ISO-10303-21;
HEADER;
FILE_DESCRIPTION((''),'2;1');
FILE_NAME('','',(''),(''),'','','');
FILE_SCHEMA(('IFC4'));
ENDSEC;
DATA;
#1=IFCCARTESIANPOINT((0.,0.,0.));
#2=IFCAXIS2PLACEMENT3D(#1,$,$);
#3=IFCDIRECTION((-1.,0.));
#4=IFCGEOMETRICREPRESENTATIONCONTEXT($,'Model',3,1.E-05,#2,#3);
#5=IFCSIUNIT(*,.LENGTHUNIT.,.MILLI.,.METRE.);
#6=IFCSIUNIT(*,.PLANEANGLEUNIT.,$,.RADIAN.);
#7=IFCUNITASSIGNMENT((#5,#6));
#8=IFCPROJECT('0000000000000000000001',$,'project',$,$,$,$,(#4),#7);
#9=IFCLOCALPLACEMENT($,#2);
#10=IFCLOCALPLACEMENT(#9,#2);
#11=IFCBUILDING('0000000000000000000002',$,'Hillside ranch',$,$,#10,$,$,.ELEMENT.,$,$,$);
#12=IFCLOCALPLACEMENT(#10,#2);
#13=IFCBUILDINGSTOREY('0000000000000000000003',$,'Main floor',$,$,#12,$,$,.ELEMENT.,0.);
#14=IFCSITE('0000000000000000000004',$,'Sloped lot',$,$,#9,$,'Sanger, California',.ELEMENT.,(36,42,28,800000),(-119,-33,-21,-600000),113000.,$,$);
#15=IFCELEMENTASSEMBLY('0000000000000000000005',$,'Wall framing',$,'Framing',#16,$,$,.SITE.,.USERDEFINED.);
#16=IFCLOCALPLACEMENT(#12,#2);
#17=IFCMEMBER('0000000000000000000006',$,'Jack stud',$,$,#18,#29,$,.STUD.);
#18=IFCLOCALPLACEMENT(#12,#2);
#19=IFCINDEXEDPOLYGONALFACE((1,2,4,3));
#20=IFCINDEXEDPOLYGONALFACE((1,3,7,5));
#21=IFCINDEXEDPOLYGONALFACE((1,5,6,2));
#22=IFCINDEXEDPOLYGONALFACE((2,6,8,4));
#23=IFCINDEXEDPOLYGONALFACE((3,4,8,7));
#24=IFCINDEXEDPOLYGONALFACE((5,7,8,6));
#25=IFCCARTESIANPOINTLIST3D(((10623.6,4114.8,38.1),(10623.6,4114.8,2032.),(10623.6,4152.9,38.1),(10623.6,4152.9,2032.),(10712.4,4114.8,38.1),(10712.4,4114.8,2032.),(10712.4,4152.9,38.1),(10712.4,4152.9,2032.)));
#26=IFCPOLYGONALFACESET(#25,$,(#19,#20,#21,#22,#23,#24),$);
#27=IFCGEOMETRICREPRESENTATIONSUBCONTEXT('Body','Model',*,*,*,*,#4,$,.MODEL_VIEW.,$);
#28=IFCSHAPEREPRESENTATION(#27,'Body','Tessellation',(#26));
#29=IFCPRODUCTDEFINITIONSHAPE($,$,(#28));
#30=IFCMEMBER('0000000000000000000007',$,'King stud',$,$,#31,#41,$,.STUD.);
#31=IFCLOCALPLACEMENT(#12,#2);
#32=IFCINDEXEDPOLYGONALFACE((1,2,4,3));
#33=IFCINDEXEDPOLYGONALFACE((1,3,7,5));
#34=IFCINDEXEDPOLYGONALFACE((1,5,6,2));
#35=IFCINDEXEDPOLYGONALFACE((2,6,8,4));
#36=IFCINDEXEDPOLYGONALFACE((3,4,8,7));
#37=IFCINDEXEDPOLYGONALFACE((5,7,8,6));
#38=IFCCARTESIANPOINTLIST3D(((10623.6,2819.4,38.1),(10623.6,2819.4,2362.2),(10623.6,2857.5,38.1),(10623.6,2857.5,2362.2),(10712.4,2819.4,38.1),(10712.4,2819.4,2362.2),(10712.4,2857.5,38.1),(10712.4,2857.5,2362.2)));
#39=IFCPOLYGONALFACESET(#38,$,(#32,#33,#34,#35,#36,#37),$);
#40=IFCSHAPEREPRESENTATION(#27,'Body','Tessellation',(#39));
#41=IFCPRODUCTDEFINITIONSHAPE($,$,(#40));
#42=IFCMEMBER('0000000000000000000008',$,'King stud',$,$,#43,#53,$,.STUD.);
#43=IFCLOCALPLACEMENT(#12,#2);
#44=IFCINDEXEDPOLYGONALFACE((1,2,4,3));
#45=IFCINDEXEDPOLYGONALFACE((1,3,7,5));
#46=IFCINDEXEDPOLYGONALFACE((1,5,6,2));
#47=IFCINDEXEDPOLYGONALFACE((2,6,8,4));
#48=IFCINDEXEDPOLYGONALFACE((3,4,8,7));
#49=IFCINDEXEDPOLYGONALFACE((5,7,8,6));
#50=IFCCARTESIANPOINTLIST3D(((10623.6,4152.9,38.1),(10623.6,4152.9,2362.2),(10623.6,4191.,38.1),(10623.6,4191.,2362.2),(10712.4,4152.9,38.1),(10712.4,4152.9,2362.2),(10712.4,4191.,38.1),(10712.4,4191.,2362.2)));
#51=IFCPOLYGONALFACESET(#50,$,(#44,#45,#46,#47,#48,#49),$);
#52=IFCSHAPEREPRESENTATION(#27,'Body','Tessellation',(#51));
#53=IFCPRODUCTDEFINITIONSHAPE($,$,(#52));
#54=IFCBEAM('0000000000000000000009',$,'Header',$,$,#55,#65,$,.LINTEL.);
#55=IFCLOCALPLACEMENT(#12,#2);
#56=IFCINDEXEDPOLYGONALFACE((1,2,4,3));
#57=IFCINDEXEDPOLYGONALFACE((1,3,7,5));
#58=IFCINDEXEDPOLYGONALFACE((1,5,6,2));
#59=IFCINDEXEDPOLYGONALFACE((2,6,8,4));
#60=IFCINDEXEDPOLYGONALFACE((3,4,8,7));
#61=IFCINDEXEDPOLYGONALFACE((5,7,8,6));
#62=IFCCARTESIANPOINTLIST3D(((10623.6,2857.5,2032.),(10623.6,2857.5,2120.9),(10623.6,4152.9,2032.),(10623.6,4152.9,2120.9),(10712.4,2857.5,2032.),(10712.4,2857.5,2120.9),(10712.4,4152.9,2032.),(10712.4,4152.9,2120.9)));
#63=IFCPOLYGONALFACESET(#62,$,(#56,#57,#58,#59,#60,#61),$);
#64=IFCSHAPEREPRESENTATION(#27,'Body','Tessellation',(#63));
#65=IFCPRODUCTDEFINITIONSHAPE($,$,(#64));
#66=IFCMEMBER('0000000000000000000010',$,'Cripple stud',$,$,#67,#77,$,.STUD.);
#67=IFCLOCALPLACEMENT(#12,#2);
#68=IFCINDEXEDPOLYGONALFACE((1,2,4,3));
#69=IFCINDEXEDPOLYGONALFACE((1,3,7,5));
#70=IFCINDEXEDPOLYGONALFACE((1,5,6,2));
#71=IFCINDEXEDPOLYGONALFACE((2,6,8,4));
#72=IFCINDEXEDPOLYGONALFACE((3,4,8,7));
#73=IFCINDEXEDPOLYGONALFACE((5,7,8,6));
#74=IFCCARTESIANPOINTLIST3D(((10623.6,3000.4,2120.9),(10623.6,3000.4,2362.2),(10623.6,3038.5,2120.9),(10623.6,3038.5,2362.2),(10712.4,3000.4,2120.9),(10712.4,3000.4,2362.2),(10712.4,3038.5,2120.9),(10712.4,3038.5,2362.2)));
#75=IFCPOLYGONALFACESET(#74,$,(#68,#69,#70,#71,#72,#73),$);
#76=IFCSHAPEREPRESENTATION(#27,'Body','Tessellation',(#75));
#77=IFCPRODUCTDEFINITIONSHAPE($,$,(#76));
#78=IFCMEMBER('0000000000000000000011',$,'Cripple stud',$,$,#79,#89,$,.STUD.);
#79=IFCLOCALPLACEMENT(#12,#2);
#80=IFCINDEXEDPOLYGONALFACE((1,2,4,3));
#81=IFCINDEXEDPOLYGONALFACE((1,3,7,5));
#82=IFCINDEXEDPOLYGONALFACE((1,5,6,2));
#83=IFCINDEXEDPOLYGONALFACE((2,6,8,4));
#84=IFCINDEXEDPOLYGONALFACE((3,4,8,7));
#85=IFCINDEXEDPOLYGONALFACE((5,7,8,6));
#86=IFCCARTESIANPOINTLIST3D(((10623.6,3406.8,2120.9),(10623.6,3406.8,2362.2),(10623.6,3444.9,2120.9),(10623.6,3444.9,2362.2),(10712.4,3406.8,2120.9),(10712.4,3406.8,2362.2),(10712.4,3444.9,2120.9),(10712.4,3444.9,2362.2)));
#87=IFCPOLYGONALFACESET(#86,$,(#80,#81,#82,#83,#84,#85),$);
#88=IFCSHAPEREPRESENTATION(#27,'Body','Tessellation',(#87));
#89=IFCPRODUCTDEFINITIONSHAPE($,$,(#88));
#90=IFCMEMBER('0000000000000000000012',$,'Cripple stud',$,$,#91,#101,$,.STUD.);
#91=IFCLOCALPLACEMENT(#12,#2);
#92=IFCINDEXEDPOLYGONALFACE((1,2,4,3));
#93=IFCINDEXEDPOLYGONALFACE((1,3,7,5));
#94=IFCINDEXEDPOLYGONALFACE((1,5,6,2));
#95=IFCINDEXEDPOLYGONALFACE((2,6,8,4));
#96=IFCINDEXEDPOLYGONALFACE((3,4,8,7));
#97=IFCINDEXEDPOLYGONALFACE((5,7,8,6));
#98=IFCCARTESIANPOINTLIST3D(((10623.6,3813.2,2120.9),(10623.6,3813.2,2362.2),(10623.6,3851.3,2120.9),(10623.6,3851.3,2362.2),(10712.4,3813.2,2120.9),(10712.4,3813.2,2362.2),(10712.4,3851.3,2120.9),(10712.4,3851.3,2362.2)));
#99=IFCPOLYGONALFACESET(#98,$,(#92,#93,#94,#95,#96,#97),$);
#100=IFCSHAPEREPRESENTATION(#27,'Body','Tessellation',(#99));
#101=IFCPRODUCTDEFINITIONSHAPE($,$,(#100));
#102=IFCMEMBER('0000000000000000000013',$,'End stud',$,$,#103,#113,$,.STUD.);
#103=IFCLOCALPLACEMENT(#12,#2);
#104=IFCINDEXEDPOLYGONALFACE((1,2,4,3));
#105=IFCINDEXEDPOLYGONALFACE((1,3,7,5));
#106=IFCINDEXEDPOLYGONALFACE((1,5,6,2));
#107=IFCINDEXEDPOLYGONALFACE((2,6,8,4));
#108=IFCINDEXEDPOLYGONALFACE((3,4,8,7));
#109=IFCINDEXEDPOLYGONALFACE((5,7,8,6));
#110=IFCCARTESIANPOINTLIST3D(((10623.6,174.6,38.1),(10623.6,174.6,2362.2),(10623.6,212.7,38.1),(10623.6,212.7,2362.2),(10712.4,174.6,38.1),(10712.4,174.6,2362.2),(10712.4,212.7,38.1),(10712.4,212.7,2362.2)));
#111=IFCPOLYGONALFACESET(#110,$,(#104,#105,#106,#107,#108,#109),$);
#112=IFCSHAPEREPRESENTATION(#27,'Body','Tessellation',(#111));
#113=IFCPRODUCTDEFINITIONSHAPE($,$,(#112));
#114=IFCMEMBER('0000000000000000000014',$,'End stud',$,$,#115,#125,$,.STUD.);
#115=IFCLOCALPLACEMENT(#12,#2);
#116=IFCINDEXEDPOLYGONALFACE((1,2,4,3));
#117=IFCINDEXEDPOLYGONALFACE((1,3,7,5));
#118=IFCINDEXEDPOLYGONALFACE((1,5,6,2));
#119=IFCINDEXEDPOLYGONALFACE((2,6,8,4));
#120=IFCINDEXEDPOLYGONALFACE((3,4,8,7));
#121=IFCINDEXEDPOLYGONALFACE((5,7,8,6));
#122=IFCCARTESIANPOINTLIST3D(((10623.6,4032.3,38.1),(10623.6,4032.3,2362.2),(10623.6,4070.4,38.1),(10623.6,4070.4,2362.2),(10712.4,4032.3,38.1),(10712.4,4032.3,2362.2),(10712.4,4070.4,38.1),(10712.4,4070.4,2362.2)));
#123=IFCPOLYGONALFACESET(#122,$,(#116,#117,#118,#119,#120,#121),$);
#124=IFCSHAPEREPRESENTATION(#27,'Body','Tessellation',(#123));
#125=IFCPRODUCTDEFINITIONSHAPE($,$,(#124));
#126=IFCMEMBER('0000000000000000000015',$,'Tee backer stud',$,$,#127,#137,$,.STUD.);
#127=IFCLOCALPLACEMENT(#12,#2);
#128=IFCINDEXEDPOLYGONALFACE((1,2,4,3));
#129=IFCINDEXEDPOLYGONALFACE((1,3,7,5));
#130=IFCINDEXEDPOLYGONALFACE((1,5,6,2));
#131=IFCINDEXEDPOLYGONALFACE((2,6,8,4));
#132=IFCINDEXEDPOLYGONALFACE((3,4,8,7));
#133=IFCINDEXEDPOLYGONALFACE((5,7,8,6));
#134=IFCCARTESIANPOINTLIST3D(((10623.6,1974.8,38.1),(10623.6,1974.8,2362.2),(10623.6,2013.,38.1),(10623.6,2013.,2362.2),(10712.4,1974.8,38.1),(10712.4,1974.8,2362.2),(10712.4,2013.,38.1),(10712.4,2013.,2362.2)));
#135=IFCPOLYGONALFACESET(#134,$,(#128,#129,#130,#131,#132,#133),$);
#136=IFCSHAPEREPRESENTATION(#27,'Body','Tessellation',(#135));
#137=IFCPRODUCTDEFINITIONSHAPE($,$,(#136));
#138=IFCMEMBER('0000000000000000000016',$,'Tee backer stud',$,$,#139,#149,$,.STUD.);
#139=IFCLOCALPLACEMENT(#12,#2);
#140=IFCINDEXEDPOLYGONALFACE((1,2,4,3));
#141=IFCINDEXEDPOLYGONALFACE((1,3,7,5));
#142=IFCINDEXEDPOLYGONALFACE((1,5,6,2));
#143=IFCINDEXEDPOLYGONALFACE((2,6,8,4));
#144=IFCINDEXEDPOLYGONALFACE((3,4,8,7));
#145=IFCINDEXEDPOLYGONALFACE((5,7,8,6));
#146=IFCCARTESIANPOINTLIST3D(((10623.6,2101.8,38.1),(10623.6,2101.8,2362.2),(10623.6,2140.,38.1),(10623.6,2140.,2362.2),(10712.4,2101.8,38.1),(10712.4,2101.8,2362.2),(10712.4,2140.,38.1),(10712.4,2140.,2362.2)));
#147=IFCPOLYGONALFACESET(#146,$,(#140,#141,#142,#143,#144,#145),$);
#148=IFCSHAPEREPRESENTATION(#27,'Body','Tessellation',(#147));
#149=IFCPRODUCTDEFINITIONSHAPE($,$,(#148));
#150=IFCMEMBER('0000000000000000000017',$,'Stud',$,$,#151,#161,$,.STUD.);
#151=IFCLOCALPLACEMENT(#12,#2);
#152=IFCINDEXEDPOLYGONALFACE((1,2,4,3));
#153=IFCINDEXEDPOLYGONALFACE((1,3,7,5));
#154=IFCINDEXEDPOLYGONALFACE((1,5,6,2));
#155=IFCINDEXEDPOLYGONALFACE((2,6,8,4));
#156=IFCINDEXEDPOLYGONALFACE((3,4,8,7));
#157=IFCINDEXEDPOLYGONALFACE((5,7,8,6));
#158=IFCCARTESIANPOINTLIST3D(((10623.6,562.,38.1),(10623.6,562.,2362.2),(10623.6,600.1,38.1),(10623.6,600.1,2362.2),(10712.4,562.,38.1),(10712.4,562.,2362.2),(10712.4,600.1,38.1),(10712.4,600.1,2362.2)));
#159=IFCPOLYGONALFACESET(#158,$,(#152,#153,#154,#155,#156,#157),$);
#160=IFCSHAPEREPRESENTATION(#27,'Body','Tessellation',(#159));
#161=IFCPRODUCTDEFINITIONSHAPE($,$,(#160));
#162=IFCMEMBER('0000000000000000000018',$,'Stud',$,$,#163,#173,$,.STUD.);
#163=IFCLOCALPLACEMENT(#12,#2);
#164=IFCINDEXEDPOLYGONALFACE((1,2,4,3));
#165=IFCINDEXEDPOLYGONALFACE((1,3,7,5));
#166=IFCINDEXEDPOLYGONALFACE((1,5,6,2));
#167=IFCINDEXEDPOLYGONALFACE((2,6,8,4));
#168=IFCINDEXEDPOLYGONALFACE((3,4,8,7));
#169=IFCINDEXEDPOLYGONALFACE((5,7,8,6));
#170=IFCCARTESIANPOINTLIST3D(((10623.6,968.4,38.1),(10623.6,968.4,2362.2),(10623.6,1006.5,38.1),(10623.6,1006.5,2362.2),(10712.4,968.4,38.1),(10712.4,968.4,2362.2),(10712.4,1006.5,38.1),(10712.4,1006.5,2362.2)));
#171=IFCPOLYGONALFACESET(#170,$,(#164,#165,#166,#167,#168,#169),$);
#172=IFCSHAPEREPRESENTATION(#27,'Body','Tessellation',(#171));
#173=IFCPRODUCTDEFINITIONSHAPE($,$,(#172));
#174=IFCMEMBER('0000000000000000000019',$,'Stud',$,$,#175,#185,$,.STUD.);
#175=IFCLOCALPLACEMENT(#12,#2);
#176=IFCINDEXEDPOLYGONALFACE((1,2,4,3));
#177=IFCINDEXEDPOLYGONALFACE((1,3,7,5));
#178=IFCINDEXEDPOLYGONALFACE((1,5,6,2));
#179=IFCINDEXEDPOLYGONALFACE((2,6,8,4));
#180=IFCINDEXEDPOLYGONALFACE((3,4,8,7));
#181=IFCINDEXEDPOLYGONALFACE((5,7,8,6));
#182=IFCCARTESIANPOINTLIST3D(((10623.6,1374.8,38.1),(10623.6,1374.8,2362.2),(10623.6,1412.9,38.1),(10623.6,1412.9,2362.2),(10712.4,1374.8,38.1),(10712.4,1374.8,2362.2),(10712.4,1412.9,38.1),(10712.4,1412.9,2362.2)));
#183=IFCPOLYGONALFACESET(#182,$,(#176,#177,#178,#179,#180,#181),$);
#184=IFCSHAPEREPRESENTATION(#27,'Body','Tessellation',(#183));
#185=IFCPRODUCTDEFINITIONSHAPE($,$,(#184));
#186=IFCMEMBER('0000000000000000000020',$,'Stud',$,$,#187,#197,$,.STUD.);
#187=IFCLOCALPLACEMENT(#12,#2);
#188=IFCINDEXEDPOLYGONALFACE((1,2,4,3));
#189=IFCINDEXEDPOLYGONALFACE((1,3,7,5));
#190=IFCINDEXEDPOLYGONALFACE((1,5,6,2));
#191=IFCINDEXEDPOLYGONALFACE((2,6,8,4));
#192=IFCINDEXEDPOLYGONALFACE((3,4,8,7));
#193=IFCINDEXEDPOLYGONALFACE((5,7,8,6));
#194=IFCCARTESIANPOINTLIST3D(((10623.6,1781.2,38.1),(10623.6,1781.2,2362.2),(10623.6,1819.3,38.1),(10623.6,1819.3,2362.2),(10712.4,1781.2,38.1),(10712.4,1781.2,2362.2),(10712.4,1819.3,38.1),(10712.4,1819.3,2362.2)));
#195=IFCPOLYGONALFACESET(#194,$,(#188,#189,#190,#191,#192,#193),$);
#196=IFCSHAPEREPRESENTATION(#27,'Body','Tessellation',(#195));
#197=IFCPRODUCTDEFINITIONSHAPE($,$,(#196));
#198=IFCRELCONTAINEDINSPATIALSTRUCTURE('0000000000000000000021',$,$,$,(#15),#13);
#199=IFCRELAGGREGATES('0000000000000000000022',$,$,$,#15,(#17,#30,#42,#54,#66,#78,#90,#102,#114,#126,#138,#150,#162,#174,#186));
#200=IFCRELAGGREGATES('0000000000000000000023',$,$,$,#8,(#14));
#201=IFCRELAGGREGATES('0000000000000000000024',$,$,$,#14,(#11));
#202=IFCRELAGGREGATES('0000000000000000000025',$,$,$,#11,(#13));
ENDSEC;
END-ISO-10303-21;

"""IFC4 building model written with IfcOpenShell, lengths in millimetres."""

from ifc_helpers import new_model, si_unit, direction, frame, origin, origin_with_axes, place, context, subcontext, project, spatial, polyline, outline, extrude, element, aggregate, save


model = new_model("IFC4")

# Units and contexts
model_context = context("Model", 3, precision=1e-05, world=origin(), true_north=direction((-1.0, 0.0)))
body_context = subcontext(model_context, "Body", "Model", "MODEL_VIEW")
ifc_project = project(units=[si_unit("LENGTHUNIT", "METRE", prefix="MILLI"), si_unit("PLANEANGLEUNIT", "RADIAN")], contexts=[model_context])

# Site, building, storey
site_placement = place(None, origin())
site = spatial("IfcSite", under=ifc_project, at=site_placement, Name="Sloped lot", LongName="Sanger, California", CompositionType="ELEMENT", RefLatitude=(36, 42, 28, 800000), RefLongitude=(-119, -33, -21, -600000), RefElevation=113000.0)
building_placement = place(site_placement, origin())
building = spatial("IfcBuilding", under=site, at=building_placement, Name="Hillside ranch", CompositionType="ELEMENT")
storey_placement = place(building_placement, origin())
storey = spatial("IfcBuildingStorey", under=building, at=storey_placement, Name="Main floor", CompositionType="ELEMENT", Elevation=0.0)

# Element assembly, members, beam
assembly_placement = place(storey_placement, origin_with_axes())
assembly = element("IfcElementAssembly", 1, at=assembly_placement, inside=storey, Name="Wall framing", ObjectType="Framing", AssemblyPlace="SITE", PredefinedType="USERDEFINED")
member_1_placement = place(storey_placement, origin_with_axes())
member_1 = element("IfcMember", 2, at=member_1_placement, Name="Jack stud", PredefinedType="STUD", context=body_context, shape_type="SweptSolid", body=[
    extrude(outline(polyline([(0.0, 0.0), (38.1, 0.0), (38.1, 88.9), (0.0, 88.9), (0.0, 0.0)])), frame((10712.5, 4114.8, 38.1), z_axis=(0.0, 0.0, 1.0), x_axis=(0.0, 1.0, 0.0)), (0.0, 0.0, 1.0), 1993.9),
])
member_2_placement = place(storey_placement, origin_with_axes())
member_2 = element("IfcMember", 3, at=member_2_placement, Name="King stud", PredefinedType="STUD", context=body_context, shape_type="SweptSolid", body=[
    extrude(outline(polyline([(0.0, 0.0), (38.1, 0.0), (38.1, 88.9), (0.0, 88.9), (0.0, 0.0)])), frame((10712.5, 2819.4, 38.1), z_axis=(0.0, 0.0, 1.0), x_axis=(0.0, 1.0, 0.0)), (0.0, 0.0, 1.0), 2324.1),
])
member_3_placement = place(storey_placement, origin_with_axes())
member_3 = element("IfcMember", 4, at=member_3_placement, Name="King stud", PredefinedType="STUD", context=body_context, shape_type="SweptSolid", body=[
    extrude(outline(polyline([(0.0, 0.0), (38.1, 0.0), (38.1, 88.9), (0.0, 88.9), (0.0, 0.0)])), frame((10712.5, 4152.9, 38.1), z_axis=(0.0, 0.0, 1.0), x_axis=(0.0, 1.0, 0.0)), (0.0, 0.0, 1.0), 2324.1),
])
beam_placement = place(storey_placement, origin_with_axes())
beam = element("IfcBeam", 5, at=beam_placement, Name="Header", PredefinedType="LINTEL", context=body_context, shape_type="SweptSolid", body=[
    extrude(outline(polyline([(0.0, 0.0), (1295.4, 0.0), (1295.4, 88.9), (0.0, 88.9), (0.0, 0.0)])), frame((10712.5, 2857.5, 2032.0), z_axis=(0.0, 0.0, 1.0), x_axis=(0.0, 1.0, 0.0)), (0.0, 0.0, 1.0), 88.9),
])
member_4_placement = place(storey_placement, origin_with_axes())
member_4 = element("IfcMember", 6, at=member_4_placement, Name="Cripple stud", PredefinedType="STUD", context=body_context, shape_type="SweptSolid", body=[
    extrude(outline(polyline([(0.0, 0.0), (38.1, 0.0), (38.1, 88.9), (0.0, 88.9), (0.0, 0.0)])), frame((10712.5, 3000.4, 2120.9), z_axis=(0.0, 0.0, 1.0), x_axis=(0.0, 1.0, 0.0)), (0.0, 0.0, 1.0), 241.3),
])
member_5_placement = place(storey_placement, origin_with_axes())
member_5 = element("IfcMember", 7, at=member_5_placement, Name="Cripple stud", PredefinedType="STUD", context=body_context, shape_type="SweptSolid", body=[
    extrude(outline(polyline([(0.0, 0.0), (38.1, 0.0), (38.1, 88.9), (0.0, 88.9), (0.0, 0.0)])), frame((10712.5, 3406.8, 2120.9), z_axis=(0.0, 0.0, 1.0), x_axis=(0.0, 1.0, 0.0)), (0.0, 0.0, 1.0), 241.3),
])
member_6_placement = place(storey_placement, origin_with_axes())
member_6 = element("IfcMember", 8, at=member_6_placement, Name="Cripple stud", PredefinedType="STUD", context=body_context, shape_type="SweptSolid", body=[
    extrude(outline(polyline([(0.0, 0.0), (38.1, 0.0), (38.1, 88.9), (0.0, 88.9), (0.0, 0.0)])), frame((10712.5, 3813.2, 2120.9), z_axis=(0.0, 0.0, 1.0), x_axis=(0.0, 1.0, 0.0)), (0.0, 0.0, 1.0), 241.3),
])
member_7_placement = place(storey_placement, origin_with_axes())
member_7 = element("IfcMember", 9, at=member_7_placement, Name="End stud", PredefinedType="STUD", context=body_context, shape_type="SweptSolid", body=[
    extrude(outline(polyline([(0.0, 0.0), (38.1, 0.0), (38.1, 88.9), (0.0, 88.9), (0.0, 0.0)])), frame((10712.5, 174.6, 38.1), z_axis=(0.0, 0.0, 1.0), x_axis=(0.0, 1.0, 0.0)), (0.0, 0.0, 1.0), 2324.1),
])
member_8_placement = place(storey_placement, origin_with_axes())
member_8 = element("IfcMember", 10, at=member_8_placement, Name="End stud", PredefinedType="STUD", context=body_context, shape_type="SweptSolid", body=[
    extrude(outline(polyline([(0.0, 0.0), (38.1, 0.0), (38.1, 88.9), (0.0, 88.9), (0.0, 0.0)])), frame((10712.5, 4032.2, 38.1), z_axis=(0.0, 0.0, 1.0), x_axis=(0.0, 1.0, 0.0)), (0.0, 0.0, 1.0), 2324.1),
])
member_9_placement = place(storey_placement, origin_with_axes())
member_9 = element("IfcMember", 11, at=member_9_placement, Name="Tee backer stud", PredefinedType="STUD", context=body_context, shape_type="SweptSolid", body=[
    extrude(outline(polyline([(0.0, 0.0), (38.1, 0.0), (38.1, 88.9), (0.0, 88.9), (0.0, 0.0)])), frame((10712.5, 1974.8, 38.1), z_axis=(0.0, 0.0, 1.0), x_axis=(0.0, 1.0, 0.0)), (0.0, 0.0, 1.0), 2324.1),
])
member_10_placement = place(storey_placement, origin_with_axes())
member_10 = element("IfcMember", 12, at=member_10_placement, Name="Tee backer stud", PredefinedType="STUD", context=body_context, shape_type="SweptSolid", body=[
    extrude(outline(polyline([(0.0, 0.0), (38.1, 0.0), (38.1, 88.9), (0.0, 88.9), (0.0, 0.0)])), frame((10712.5, 2101.8, 38.1), z_axis=(0.0, 0.0, 1.0), x_axis=(0.0, 1.0, 0.0)), (0.0, 0.0, 1.0), 2324.1),
])
member_11_placement = place(storey_placement, origin_with_axes())
member_11 = element("IfcMember", 13, at=member_11_placement, Name="Stud", PredefinedType="STUD", context=body_context, shape_type="SweptSolid", body=[
    extrude(outline(polyline([(0.0, 0.0), (38.1, 0.0), (38.1, 88.9), (0.0, 88.9), (0.0, 0.0)])), frame((10712.5, 562.0, 38.1), z_axis=(0.0, 0.0, 1.0), x_axis=(0.0, 1.0, 0.0)), (0.0, 0.0, 1.0), 2324.1),
])
member_12_placement = place(storey_placement, origin_with_axes())
member_12 = element("IfcMember", 14, at=member_12_placement, Name="Stud", PredefinedType="STUD", context=body_context, shape_type="SweptSolid", body=[
    extrude(outline(polyline([(0.0, 0.0), (38.1, 0.0), (38.1, 88.9), (0.0, 88.9), (0.0, 0.0)])), frame((10712.5, 968.4, 38.1), z_axis=(0.0, 0.0, 1.0), x_axis=(0.0, 1.0, 0.0)), (0.0, 0.0, 1.0), 2324.1),
])
member_13_placement = place(storey_placement, origin_with_axes())
member_13 = element("IfcMember", 15, at=member_13_placement, Name="Stud", PredefinedType="STUD", context=body_context, shape_type="SweptSolid", body=[
    extrude(outline(polyline([(0.0, 0.0), (38.1, 0.0), (38.1, 88.9), (0.0, 88.9), (0.0, 0.0)])), frame((10712.5, 1374.8, 38.1), z_axis=(0.0, 0.0, 1.0), x_axis=(0.0, 1.0, 0.0)), (0.0, 0.0, 1.0), 2324.1),
])
member_14_placement = place(storey_placement, origin_with_axes())
member_14 = element("IfcMember", 16, at=member_14_placement, Name="Stud", PredefinedType="STUD", context=body_context, shape_type="SweptSolid", body=[
    extrude(outline(polyline([(0.0, 0.0), (38.1, 0.0), (38.1, 88.9), (0.0, 88.9), (0.0, 0.0)])), frame((10712.5, 1781.2, 38.1), z_axis=(0.0, 0.0, 1.0), x_axis=(0.0, 1.0, 0.0)), (0.0, 0.0, 1.0), 2324.1),
])
aggregate(assembly, [member_1, member_2, member_3, beam, member_4, member_5, member_6, member_7, member_8, member_9, member_10, member_11, member_12, member_13, member_14])

save(model, "model.ifc")
